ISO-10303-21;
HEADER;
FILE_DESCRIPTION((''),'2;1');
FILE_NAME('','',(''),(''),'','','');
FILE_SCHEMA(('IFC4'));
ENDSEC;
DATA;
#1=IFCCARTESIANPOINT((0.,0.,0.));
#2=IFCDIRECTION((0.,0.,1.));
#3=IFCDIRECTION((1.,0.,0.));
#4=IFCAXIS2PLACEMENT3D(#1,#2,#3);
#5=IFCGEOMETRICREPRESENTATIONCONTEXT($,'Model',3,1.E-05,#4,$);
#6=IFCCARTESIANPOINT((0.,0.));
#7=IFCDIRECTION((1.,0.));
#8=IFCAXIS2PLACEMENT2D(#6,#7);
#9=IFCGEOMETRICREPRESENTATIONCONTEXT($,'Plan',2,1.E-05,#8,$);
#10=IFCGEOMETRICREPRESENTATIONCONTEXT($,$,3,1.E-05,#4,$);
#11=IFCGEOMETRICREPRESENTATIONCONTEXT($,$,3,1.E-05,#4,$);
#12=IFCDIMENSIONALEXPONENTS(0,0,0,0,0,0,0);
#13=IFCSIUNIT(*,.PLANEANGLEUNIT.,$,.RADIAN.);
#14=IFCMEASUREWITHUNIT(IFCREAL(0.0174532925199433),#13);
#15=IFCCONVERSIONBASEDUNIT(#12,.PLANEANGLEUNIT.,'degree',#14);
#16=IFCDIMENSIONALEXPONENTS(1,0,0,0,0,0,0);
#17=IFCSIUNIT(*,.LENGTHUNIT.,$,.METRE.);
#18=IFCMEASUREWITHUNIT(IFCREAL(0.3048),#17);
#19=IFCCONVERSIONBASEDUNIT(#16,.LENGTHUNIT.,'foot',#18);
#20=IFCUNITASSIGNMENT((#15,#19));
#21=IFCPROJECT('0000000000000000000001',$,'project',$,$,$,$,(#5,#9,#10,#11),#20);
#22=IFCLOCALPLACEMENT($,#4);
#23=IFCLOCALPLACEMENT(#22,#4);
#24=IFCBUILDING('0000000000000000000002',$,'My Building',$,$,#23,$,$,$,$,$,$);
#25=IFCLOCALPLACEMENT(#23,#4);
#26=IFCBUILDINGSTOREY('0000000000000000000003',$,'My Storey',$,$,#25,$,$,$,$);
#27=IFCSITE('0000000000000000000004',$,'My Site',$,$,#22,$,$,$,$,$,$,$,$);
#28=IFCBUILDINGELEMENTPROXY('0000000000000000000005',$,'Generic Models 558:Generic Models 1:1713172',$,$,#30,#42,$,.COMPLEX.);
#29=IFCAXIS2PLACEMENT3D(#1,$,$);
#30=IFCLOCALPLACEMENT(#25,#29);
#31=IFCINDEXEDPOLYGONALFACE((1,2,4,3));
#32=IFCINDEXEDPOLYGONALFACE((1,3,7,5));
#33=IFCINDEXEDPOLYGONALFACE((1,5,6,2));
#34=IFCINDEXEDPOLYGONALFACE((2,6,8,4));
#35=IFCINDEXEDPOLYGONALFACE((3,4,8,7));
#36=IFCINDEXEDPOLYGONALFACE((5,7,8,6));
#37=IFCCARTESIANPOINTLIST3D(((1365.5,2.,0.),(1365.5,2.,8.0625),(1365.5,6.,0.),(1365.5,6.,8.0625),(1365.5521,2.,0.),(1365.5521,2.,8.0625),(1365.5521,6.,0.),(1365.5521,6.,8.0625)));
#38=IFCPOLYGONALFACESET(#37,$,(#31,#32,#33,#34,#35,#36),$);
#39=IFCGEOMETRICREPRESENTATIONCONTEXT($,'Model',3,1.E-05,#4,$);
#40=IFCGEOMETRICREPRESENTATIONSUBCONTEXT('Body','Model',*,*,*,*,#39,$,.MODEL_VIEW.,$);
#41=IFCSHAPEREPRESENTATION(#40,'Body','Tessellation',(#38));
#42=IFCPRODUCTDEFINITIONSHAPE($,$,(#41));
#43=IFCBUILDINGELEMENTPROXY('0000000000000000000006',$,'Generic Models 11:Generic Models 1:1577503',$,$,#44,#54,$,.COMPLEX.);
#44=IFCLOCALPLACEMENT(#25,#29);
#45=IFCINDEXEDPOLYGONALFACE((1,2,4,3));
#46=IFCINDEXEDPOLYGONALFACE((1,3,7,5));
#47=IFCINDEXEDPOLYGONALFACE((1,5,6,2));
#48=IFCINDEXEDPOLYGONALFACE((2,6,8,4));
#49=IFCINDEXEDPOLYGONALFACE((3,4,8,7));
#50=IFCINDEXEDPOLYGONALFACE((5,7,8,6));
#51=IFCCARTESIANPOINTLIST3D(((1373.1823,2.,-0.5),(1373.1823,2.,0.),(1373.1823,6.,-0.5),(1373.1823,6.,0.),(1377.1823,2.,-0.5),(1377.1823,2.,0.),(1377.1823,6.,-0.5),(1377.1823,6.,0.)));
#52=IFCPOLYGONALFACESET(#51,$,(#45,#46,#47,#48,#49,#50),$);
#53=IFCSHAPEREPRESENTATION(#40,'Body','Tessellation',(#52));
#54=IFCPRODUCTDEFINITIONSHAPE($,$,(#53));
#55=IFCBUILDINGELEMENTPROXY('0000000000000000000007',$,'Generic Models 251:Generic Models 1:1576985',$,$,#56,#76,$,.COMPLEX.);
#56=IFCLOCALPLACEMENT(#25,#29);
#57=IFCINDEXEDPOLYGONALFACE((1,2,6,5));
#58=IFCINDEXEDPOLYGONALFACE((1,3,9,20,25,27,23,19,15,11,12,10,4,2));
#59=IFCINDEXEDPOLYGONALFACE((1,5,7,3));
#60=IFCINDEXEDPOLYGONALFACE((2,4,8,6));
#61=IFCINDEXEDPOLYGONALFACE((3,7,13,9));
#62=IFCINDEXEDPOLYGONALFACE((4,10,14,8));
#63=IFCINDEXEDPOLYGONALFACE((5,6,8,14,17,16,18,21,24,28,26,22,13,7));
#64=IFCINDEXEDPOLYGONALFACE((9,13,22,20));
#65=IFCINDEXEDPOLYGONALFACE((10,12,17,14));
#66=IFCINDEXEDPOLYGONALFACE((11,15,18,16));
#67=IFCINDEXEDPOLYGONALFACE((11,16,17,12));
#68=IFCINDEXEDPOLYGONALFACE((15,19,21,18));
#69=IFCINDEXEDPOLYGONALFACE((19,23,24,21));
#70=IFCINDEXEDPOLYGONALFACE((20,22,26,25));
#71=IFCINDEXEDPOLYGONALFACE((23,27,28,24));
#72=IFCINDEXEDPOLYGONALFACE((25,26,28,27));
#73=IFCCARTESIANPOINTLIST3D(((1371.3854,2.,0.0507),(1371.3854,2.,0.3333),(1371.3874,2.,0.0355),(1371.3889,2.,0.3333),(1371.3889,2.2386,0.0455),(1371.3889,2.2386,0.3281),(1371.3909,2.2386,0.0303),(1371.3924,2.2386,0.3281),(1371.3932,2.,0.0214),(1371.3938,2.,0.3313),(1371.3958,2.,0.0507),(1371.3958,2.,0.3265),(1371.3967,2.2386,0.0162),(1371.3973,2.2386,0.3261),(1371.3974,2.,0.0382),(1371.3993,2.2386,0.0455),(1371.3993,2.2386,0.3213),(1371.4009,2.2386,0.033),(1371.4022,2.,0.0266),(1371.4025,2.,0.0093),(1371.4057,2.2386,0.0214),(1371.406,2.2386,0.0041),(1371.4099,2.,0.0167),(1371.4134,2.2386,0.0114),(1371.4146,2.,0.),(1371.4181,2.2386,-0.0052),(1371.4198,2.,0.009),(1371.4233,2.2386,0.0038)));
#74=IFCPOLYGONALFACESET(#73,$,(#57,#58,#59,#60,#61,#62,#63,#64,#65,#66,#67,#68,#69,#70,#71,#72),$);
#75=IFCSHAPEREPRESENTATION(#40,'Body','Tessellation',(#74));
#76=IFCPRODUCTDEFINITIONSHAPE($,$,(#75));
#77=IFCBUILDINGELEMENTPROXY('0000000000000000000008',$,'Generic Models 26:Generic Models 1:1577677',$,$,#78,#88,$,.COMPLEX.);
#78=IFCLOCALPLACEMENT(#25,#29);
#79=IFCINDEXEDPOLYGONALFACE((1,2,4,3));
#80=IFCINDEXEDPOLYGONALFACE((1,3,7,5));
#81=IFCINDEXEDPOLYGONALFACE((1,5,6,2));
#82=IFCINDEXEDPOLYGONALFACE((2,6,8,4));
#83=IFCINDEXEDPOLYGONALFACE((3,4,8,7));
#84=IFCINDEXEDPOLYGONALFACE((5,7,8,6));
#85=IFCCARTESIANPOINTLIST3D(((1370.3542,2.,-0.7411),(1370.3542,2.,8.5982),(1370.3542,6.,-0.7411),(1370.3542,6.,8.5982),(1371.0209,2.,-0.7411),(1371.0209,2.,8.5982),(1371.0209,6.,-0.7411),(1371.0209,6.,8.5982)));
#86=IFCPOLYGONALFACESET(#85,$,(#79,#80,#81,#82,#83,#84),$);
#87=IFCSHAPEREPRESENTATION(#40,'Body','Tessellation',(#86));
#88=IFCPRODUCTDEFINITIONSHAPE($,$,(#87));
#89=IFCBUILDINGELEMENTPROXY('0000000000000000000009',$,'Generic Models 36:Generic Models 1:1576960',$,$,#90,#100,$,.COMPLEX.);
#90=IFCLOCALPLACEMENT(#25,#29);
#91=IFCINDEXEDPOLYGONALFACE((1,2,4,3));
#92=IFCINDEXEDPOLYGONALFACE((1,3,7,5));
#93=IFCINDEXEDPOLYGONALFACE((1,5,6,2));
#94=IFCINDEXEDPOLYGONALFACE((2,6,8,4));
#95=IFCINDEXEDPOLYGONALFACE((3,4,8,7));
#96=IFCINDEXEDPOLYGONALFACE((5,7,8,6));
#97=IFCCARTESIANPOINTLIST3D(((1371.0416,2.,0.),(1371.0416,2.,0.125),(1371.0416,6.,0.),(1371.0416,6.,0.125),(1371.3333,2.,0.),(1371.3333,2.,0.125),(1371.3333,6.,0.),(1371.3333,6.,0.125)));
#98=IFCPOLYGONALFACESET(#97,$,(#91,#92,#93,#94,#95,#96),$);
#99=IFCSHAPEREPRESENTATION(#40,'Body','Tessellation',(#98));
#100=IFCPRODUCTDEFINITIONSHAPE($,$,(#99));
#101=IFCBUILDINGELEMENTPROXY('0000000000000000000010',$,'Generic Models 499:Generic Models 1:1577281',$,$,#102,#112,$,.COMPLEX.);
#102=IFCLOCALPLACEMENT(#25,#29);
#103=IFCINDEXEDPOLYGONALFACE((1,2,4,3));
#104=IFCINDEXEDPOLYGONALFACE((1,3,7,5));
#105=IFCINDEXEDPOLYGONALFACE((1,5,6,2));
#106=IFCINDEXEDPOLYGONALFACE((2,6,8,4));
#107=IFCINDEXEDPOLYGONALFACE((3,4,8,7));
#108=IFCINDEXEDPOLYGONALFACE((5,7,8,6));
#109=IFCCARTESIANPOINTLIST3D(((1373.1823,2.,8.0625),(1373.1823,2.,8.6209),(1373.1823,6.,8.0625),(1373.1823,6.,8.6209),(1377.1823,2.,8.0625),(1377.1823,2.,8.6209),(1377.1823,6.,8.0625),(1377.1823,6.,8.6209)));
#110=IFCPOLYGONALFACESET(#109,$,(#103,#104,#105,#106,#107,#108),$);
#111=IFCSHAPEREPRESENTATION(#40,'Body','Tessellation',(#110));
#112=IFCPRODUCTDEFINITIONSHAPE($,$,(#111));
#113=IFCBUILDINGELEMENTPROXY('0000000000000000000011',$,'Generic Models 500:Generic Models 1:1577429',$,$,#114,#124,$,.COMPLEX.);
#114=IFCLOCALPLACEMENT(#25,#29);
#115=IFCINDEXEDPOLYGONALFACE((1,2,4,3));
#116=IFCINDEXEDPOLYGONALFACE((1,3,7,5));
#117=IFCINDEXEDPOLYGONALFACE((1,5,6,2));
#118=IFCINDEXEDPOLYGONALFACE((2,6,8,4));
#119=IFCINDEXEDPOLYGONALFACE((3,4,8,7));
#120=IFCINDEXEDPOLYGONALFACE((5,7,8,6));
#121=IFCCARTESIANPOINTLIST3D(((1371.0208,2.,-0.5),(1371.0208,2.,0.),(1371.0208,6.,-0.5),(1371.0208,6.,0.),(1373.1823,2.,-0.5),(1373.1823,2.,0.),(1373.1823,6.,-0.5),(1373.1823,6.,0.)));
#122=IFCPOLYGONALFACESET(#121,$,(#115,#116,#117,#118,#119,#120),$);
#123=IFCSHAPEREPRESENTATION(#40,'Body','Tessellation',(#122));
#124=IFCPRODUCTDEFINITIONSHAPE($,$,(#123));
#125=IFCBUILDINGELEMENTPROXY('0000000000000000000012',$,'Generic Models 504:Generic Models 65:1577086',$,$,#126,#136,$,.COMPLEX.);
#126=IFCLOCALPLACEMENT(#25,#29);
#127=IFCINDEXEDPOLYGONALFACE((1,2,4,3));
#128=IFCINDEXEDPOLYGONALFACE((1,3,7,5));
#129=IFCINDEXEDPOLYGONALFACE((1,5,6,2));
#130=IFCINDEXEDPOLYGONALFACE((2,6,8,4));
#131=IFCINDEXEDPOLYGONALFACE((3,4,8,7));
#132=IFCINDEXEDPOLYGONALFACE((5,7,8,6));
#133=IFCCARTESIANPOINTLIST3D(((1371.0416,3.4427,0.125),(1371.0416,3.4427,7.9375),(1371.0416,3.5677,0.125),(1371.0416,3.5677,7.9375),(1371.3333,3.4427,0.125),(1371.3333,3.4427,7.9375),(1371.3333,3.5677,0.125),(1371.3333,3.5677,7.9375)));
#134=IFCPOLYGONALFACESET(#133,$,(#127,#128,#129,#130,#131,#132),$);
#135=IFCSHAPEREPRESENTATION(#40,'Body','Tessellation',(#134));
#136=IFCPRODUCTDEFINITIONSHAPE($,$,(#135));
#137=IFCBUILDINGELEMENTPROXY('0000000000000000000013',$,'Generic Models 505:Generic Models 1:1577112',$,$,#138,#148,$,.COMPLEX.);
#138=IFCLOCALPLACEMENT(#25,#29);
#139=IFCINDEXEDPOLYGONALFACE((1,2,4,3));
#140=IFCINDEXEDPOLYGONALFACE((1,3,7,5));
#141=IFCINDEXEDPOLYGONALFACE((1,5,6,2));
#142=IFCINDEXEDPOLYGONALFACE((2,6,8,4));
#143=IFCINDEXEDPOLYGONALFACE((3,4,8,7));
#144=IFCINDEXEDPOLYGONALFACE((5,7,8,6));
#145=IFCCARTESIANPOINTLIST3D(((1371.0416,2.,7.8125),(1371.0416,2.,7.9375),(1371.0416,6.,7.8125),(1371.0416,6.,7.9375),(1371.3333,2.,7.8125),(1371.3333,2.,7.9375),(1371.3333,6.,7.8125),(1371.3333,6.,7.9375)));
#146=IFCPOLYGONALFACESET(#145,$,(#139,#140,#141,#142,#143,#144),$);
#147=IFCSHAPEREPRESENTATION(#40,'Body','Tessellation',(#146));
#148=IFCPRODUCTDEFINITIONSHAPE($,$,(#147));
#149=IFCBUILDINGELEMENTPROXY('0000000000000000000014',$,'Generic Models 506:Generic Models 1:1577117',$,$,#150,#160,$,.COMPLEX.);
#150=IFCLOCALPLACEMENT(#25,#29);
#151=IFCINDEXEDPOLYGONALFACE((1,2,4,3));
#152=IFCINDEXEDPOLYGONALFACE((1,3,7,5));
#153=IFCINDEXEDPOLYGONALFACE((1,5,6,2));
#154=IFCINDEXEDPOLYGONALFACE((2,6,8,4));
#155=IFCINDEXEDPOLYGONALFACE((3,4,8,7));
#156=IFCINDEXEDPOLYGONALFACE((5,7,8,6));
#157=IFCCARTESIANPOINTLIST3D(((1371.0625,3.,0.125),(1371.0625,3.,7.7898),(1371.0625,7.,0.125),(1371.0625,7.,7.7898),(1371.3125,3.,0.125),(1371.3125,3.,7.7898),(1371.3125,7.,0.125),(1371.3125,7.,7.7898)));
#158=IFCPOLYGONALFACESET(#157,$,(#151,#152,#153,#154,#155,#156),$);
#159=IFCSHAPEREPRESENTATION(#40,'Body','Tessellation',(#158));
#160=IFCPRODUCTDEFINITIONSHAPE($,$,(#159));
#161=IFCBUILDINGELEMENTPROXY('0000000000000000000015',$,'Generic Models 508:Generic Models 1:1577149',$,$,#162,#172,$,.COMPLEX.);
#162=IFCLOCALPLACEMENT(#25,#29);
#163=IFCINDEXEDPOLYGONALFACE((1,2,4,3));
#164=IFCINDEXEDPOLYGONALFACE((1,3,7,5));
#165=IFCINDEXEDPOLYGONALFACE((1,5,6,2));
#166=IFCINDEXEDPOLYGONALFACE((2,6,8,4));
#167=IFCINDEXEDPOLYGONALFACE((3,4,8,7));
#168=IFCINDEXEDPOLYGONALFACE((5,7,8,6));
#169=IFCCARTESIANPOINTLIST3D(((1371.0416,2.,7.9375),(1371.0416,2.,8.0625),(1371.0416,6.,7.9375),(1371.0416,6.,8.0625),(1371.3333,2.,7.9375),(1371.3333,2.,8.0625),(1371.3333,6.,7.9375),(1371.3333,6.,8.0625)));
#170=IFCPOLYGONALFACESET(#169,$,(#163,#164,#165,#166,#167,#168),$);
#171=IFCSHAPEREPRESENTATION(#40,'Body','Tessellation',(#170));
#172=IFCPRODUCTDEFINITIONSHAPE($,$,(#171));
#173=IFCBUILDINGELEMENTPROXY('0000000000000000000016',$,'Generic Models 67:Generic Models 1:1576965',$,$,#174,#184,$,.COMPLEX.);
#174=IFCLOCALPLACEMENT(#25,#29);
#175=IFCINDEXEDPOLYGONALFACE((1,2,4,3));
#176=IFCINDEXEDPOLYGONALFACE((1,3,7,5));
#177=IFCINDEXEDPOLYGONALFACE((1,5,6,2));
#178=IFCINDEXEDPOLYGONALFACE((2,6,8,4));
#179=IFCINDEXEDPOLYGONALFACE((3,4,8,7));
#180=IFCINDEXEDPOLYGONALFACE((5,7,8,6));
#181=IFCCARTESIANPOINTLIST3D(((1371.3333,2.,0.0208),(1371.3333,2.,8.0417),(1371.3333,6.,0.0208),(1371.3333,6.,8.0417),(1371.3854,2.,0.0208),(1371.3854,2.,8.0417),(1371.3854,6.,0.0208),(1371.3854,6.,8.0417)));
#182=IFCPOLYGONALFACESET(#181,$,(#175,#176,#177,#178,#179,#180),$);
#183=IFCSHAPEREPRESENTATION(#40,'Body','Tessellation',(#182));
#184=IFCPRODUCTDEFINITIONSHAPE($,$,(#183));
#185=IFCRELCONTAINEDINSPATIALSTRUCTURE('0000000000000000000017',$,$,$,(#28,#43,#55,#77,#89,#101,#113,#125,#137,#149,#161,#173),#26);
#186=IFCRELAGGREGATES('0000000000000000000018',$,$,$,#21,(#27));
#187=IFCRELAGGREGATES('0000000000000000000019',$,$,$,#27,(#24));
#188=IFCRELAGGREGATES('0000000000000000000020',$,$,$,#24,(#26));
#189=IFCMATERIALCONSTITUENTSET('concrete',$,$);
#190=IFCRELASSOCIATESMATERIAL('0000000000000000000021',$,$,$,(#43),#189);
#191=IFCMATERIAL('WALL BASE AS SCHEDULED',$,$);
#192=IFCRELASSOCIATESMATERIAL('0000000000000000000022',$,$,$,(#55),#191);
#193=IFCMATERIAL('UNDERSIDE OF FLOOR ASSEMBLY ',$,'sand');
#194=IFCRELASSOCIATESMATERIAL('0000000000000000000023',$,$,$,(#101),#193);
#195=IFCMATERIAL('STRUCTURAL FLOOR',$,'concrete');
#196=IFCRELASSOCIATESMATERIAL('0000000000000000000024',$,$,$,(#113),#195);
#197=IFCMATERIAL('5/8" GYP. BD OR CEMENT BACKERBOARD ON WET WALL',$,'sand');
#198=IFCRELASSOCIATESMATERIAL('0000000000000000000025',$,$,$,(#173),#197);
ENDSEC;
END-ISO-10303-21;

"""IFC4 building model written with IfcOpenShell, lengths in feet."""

from ifc_helpers import new_model, entity, si_unit, converted_unit, frame, origin_with_axes, origin_2d_with_axis, place, context, subcontext, project, spatial, polyline, outline, extrude, material, constituent_set, element, save


model = new_model("IFC4")

# Units and contexts
model_context_1 = context("Model", 3, precision=1e-05, world=origin_with_axes())
plan_context = context("Plan", 2, precision=1e-05, world=origin_2d_with_axis())
model_context_2 = context("Model", 3, precision=1e-05, world=origin_with_axes())
context_of_model_1 = context(None, 3, precision=1e-05, world=origin_with_axes())
context_of_model_2 = context(None, 3, precision=1e-05, world=origin_with_axes())
body_context = subcontext(model_context_2, "Body", "Model", "MODEL_VIEW")
ifc_project = project(units=[converted_unit("PLANEANGLEUNIT", "degree", entity("IfcReal", 0.0174532925199433), si_unit("PLANEANGLEUNIT", "RADIAN"), dimensions=[0, 0, 0, 0, 0, 0, 0]), converted_unit("LENGTHUNIT", "foot", entity("IfcReal", 0.3048), si_unit("LENGTHUNIT", "METRE"), dimensions=[1, 0, 0, 0, 0, 0, 0])], contexts=[model_context_1, plan_context, context_of_model_1, context_of_model_2])

# Site, building, storey
site_placement = place(None, origin_with_axes())
site = spatial("IfcSite", under=ifc_project, at=site_placement, Name="My Site")
building_placement = place(site_placement, origin_with_axes())
building = spatial("IfcBuilding", under=site, at=building_placement, Name="My Building")
storey_placement = place(building_placement, origin_with_axes())
storey = spatial("IfcBuildingStorey", under=building, at=storey_placement, Name="My Storey")

# Building element proxies
proxy_1_placement = place(storey_placement, frame((1365.5, 6.0, 0.0), z_axis=(0.0, -1.0, 0.0), x_axis=(0.0, 0.0, 1.0)))
element("IfcBuildingElementProxy", 1, at=proxy_1_placement, inside=storey, Name="Generic Models 558:Generic Models 1:1713172", PredefinedType="COMPLEX", context=body_context, shape_type="SweptSolid", body=[
    extrude(outline(polyline([(-4.0312, -0.026), (4.0312, -0.026), (4.0312, 0.026), (-4.0312, 0.026), (-4.0312, -0.026)])), frame((4.0312, -0.026, 0.0), z_axis=(0.0, 0.0, -1.0), x_axis=(1.0, 0.0, 0.0)), (0.0, 0.0, -1.0), 4.0),
])
ifc_constituent_set = constituent_set(Name="concrete")
proxy_2_placement = place(storey_placement, frame((1373.1823, 6.0, -0.5), z_axis=(0.0, -1.0, 0.0), x_axis=(0.0, 0.0, -1.0)))
element("IfcBuildingElementProxy", 2, at=proxy_2_placement, inside=storey, material=ifc_constituent_set, Name="Generic Models 11:Generic Models 1:1577503", PredefinedType="COMPLEX", context=body_context, shape_type="SweptSolid", body=[
    extrude(outline(polyline([(-0.25, -2.0), (0.25, -2.0), (0.25, 2.0), (-0.25, 2.0), (-0.25, -2.0)])), frame((-0.25, 2.0, 0.0), z_axis=(0.0, 0.0, -1.0), x_axis=(-1.0, 0.0, 0.0)), (0.0, 0.0, -1.0), 4.0),
])
ifc_material_1 = material(Name="WALL BASE AS SCHEDULED")
proxy_3_placement = place(storey_placement, frame((1371.3854, 6.0, 0.0), z_axis=(0.0, -1.0, 0.0), x_axis=(0.0, 0.0, -1.0)))
element("IfcBuildingElementProxy", 3, at=proxy_3_placement, inside=storey, material=ifc_material_1, Name="Generic Models 251:Generic Models 1:1576985", PredefinedType="COMPLEX", context=body_context, shape_type="SweptSolid", body=[
    extrude(outline(polyline([(0.0971, 0.0), (0.1059, -0.009), (0.1142, -0.0027), (0.1035, 0.0082), (0.0904, 0.016), (0.0756, 0.02), (0.0603, 0.0202), (-0.2202, -0.0144), (-0.2197, -0.0179), (-0.2172, -0.0225), (-0.2121, -0.0239), (0.0616, 0.0098), (0.0742, 0.0097), (0.0863, 0.0064), (0.0971, 0.0)])), frame((-0.1078, 0.0161, 3.7614), z_axis=(-0.000001, 0.0, -1.0), x_axis=(0.992503, 0.122219, -0.000004)), (-0.023549, 0.011857, -0.999652), 0.2387),
])
proxy_4_placement = place(storey_placement, frame((1370.3542, 6.0, -0.7411), z_axis=(0.0, -1.0, 0.0), x_axis=(0.0, 0.0, -1.0)))
element("IfcBuildingElementProxy", 4, at=proxy_4_placement, inside=storey, Name="Generic Models 26:Generic Models 1:1577677", PredefinedType="COMPLEX", context=body_context, shape_type="SweptSolid", body=[
    extrude(outline(polyline([(-0.3333, -4.6697), (0.3333, -4.6697), (0.3333, 4.6697), (-0.3333, 4.6697), (-0.3333, -4.6697)])), frame((-4.6697, 0.3333, 0.0), z_axis=(0.0, 0.0, -1.0), x_axis=(0.0, -1.0, 0.0)), (0.0, 0.0, -1.0), 4.0),
])
proxy_5_placement = place(storey_placement, frame((1371.0416, 6.0, 0.0), z_axis=(0.0, -1.0, 0.0), x_axis=(0.0, 0.0, -1.0)))
element("IfcBuildingElementProxy", 5, at=proxy_5_placement, inside=storey, Name="Generic Models 36:Generic Models 1:1576960", PredefinedType="COMPLEX", context=body_context, shape_type="SweptSolid", body=[
    extrude(outline(polyline([(-0.0625, -0.1458), (0.0625, -0.1458), (0.0625, 0.1458), (-0.0625, 0.1458), (-0.0625, -0.1458)])), frame((-0.0625, 0.1458, 0.0), z_axis=(0.0, 0.0, -1.0), x_axis=(1.0, 0.0, 0.0)), (0.0, 0.0, -1.0), 4.0),
])
ifc_material_2 = material(Name="UNDERSIDE OF FLOOR ASSEMBLY ", Category="sand")
proxy_6_placement = place(storey_placement, frame((1373.1823, 6.0, 8.0625), z_axis=(0.0, -1.0, 0.0), x_axis=(0.0, 0.0, -1.0)))
element("IfcBuildingElementProxy", 6, at=proxy_6_placement, inside=storey, material=ifc_material_2, Name="Generic Models 499:Generic Models 1:1577281", PredefinedType="COMPLEX", context=body_context, shape_type="SweptSolid", body=[
    extrude(outline(polyline([(-0.2792, -2.0), (0.2792, -2.0), (0.2792, 2.0), (-0.2792, 2.0), (-0.2792, -2.0)])), frame((-0.2792, 2.0, 0.0), z_axis=(0.0, 0.0, -1.0), x_axis=(1.0, 0.0, 0.0)), (0.0, 0.0, -1.0), 4.0),
])
ifc_material_3 = material(Name="STRUCTURAL FLOOR", Category="concrete")
proxy_7_placement = place(storey_placement, frame((1371.0208, 6.0, -0.5), z_axis=(0.0, -1.0, 0.0), x_axis=(0.0, 0.0, -1.0)))
element("IfcBuildingElementProxy", 7, at=proxy_7_placement, inside=storey, material=ifc_material_3, Name="Generic Models 500:Generic Models 1:1577429", PredefinedType="COMPLEX", context=body_context, shape_type="SweptSolid", body=[
    extrude(outline(polyline([(-0.25, -1.0807), (0.25, -1.0807), (0.25, 1.0807), (-0.25, 1.0807), (-0.25, -1.0807)])), frame((-0.25, 1.0807, 0.0), z_axis=(0.0, 0.0, -1.0), x_axis=(1.0, 0.0, 0.0)), (0.0, 0.0, -1.0), 4.0),
])
proxy_8_placement = place(storey_placement, frame((1371.0416, 3.4427, 0.125), z_axis=(1.0, 0.0, 0.0), x_axis=(0.0, 0.0, -1.0)))
element("IfcBuildingElementProxy", 8, at=proxy_8_placement, inside=storey, Name="Generic Models 504:Generic Models 65:1577086", PredefinedType="COMPLEX", context=body_context, shape_type="SweptSolid", body=[
    extrude(outline(polyline([(-3.9062, -0.0625), (3.9062, -0.0625), (3.9062, 0.0625), (-3.9062, 0.0625), (-3.9062, -0.0625)])), frame((-3.9062, 0.0625, 0.0), z_axis=(0.0, 0.0, -1.0), x_axis=(1.0, 0.0, 0.0)), (0.0, 0.0, -1.0), 0.2917),
])
proxy_9_placement = place(storey_placement, frame((1371.0416, 6.0, 7.8125), z_axis=(0.0, -1.0, 0.0), x_axis=(0.0, 0.0, -1.0)))
element("IfcBuildingElementProxy", 9, at=proxy_9_placement, inside=storey, Name="Generic Models 505:Generic Models 1:1577112", PredefinedType="COMPLEX", context=body_context, shape_type="SweptSolid", body=[
    extrude(outline(polyline([(-0.0625, -0.1458), (0.0625, -0.1458), (0.0625, 0.1458), (-0.0625, 0.1458), (-0.0625, -0.1458)])), frame((-0.0625, 0.1458, 0.0), z_axis=(0.0, 0.0, -1.0), x_axis=(1.0, 0.0, 0.0)), (0.0, 0.0, -1.0), 4.0),
])
proxy_10_placement = place(storey_placement, frame((1371.0625, 3.0, 0.125), z_axis=(0.0, 1.0, 0.0), x_axis=(0.0, 0.0, -1.0)))
element("IfcBuildingElementProxy", 10, at=proxy_10_placement, inside=storey, Name="Generic Models 506:Generic Models 1:1577117", PredefinedType="COMPLEX", context=body_context, shape_type="SweptSolid", body=[
    extrude(outline(polyline([(-3.8324, -0.125), (3.8324, -0.125), (3.8324, 0.125), (-3.8324, 0.125), (-3.8324, -0.125)])), frame((-3.8324, -0.125, 0.0), z_axis=(0.0, 0.0, -1.0), x_axis=(-1.0, 0.0, 0.0)), (0.0, 0.0, -1.0), 4.0),
])
proxy_11_placement = place(storey_placement, frame((1371.0416, 6.0, 7.9375), z_axis=(0.0, -1.0, 0.0), x_axis=(0.0, 0.0, -1.0)))
element("IfcBuildingElementProxy", 11, at=proxy_11_placement, inside=storey, Name="Generic Models 508:Generic Models 1:1577149", PredefinedType="COMPLEX", context=body_context, shape_type="SweptSolid", body=[
    extrude(outline(polyline([(-0.0625, -0.1458), (0.0625, -0.1458), (0.0625, 0.1458), (-0.0625, 0.1458), (-0.0625, -0.1458)])), frame((-0.0625, 0.1458, 0.0), z_axis=(0.0, 0.0, -1.0), x_axis=(1.0, 0.0, 0.0)), (0.0, 0.0, -1.0), 4.0),
])
ifc_material_4 = material(Name="5/8\" GYP. BD OR CEMENT BACKERBOARD ON WET WALL", Category="sand")
proxy_12_placement = place(storey_placement, frame((1371.3333, 6.0, 0.0208), z_axis=(0.0, -1.0, 0.0), x_axis=(0.0, 0.0, -1.0)))
element("IfcBuildingElementProxy", 12, at=proxy_12_placement, inside=storey, material=ifc_material_4, Name="Generic Models 67:Generic Models 1:1576965", PredefinedType="COMPLEX", context=body_context, shape_type="SweptSolid", body=[
    extrude(outline(polyline([(-0.026, -4.0104), (0.026, -4.0104), (0.026, 4.0104), (-0.026, 4.0104), (-0.026, -4.0104)])), frame((-4.0104, 0.026, 0.0), z_axis=(0.0, 0.0, -1.0), x_axis=(0.0, 1.0, 0.0)), (0.0, 0.0, -1.0), 4.0),
])

save(model, "model.ifc")
